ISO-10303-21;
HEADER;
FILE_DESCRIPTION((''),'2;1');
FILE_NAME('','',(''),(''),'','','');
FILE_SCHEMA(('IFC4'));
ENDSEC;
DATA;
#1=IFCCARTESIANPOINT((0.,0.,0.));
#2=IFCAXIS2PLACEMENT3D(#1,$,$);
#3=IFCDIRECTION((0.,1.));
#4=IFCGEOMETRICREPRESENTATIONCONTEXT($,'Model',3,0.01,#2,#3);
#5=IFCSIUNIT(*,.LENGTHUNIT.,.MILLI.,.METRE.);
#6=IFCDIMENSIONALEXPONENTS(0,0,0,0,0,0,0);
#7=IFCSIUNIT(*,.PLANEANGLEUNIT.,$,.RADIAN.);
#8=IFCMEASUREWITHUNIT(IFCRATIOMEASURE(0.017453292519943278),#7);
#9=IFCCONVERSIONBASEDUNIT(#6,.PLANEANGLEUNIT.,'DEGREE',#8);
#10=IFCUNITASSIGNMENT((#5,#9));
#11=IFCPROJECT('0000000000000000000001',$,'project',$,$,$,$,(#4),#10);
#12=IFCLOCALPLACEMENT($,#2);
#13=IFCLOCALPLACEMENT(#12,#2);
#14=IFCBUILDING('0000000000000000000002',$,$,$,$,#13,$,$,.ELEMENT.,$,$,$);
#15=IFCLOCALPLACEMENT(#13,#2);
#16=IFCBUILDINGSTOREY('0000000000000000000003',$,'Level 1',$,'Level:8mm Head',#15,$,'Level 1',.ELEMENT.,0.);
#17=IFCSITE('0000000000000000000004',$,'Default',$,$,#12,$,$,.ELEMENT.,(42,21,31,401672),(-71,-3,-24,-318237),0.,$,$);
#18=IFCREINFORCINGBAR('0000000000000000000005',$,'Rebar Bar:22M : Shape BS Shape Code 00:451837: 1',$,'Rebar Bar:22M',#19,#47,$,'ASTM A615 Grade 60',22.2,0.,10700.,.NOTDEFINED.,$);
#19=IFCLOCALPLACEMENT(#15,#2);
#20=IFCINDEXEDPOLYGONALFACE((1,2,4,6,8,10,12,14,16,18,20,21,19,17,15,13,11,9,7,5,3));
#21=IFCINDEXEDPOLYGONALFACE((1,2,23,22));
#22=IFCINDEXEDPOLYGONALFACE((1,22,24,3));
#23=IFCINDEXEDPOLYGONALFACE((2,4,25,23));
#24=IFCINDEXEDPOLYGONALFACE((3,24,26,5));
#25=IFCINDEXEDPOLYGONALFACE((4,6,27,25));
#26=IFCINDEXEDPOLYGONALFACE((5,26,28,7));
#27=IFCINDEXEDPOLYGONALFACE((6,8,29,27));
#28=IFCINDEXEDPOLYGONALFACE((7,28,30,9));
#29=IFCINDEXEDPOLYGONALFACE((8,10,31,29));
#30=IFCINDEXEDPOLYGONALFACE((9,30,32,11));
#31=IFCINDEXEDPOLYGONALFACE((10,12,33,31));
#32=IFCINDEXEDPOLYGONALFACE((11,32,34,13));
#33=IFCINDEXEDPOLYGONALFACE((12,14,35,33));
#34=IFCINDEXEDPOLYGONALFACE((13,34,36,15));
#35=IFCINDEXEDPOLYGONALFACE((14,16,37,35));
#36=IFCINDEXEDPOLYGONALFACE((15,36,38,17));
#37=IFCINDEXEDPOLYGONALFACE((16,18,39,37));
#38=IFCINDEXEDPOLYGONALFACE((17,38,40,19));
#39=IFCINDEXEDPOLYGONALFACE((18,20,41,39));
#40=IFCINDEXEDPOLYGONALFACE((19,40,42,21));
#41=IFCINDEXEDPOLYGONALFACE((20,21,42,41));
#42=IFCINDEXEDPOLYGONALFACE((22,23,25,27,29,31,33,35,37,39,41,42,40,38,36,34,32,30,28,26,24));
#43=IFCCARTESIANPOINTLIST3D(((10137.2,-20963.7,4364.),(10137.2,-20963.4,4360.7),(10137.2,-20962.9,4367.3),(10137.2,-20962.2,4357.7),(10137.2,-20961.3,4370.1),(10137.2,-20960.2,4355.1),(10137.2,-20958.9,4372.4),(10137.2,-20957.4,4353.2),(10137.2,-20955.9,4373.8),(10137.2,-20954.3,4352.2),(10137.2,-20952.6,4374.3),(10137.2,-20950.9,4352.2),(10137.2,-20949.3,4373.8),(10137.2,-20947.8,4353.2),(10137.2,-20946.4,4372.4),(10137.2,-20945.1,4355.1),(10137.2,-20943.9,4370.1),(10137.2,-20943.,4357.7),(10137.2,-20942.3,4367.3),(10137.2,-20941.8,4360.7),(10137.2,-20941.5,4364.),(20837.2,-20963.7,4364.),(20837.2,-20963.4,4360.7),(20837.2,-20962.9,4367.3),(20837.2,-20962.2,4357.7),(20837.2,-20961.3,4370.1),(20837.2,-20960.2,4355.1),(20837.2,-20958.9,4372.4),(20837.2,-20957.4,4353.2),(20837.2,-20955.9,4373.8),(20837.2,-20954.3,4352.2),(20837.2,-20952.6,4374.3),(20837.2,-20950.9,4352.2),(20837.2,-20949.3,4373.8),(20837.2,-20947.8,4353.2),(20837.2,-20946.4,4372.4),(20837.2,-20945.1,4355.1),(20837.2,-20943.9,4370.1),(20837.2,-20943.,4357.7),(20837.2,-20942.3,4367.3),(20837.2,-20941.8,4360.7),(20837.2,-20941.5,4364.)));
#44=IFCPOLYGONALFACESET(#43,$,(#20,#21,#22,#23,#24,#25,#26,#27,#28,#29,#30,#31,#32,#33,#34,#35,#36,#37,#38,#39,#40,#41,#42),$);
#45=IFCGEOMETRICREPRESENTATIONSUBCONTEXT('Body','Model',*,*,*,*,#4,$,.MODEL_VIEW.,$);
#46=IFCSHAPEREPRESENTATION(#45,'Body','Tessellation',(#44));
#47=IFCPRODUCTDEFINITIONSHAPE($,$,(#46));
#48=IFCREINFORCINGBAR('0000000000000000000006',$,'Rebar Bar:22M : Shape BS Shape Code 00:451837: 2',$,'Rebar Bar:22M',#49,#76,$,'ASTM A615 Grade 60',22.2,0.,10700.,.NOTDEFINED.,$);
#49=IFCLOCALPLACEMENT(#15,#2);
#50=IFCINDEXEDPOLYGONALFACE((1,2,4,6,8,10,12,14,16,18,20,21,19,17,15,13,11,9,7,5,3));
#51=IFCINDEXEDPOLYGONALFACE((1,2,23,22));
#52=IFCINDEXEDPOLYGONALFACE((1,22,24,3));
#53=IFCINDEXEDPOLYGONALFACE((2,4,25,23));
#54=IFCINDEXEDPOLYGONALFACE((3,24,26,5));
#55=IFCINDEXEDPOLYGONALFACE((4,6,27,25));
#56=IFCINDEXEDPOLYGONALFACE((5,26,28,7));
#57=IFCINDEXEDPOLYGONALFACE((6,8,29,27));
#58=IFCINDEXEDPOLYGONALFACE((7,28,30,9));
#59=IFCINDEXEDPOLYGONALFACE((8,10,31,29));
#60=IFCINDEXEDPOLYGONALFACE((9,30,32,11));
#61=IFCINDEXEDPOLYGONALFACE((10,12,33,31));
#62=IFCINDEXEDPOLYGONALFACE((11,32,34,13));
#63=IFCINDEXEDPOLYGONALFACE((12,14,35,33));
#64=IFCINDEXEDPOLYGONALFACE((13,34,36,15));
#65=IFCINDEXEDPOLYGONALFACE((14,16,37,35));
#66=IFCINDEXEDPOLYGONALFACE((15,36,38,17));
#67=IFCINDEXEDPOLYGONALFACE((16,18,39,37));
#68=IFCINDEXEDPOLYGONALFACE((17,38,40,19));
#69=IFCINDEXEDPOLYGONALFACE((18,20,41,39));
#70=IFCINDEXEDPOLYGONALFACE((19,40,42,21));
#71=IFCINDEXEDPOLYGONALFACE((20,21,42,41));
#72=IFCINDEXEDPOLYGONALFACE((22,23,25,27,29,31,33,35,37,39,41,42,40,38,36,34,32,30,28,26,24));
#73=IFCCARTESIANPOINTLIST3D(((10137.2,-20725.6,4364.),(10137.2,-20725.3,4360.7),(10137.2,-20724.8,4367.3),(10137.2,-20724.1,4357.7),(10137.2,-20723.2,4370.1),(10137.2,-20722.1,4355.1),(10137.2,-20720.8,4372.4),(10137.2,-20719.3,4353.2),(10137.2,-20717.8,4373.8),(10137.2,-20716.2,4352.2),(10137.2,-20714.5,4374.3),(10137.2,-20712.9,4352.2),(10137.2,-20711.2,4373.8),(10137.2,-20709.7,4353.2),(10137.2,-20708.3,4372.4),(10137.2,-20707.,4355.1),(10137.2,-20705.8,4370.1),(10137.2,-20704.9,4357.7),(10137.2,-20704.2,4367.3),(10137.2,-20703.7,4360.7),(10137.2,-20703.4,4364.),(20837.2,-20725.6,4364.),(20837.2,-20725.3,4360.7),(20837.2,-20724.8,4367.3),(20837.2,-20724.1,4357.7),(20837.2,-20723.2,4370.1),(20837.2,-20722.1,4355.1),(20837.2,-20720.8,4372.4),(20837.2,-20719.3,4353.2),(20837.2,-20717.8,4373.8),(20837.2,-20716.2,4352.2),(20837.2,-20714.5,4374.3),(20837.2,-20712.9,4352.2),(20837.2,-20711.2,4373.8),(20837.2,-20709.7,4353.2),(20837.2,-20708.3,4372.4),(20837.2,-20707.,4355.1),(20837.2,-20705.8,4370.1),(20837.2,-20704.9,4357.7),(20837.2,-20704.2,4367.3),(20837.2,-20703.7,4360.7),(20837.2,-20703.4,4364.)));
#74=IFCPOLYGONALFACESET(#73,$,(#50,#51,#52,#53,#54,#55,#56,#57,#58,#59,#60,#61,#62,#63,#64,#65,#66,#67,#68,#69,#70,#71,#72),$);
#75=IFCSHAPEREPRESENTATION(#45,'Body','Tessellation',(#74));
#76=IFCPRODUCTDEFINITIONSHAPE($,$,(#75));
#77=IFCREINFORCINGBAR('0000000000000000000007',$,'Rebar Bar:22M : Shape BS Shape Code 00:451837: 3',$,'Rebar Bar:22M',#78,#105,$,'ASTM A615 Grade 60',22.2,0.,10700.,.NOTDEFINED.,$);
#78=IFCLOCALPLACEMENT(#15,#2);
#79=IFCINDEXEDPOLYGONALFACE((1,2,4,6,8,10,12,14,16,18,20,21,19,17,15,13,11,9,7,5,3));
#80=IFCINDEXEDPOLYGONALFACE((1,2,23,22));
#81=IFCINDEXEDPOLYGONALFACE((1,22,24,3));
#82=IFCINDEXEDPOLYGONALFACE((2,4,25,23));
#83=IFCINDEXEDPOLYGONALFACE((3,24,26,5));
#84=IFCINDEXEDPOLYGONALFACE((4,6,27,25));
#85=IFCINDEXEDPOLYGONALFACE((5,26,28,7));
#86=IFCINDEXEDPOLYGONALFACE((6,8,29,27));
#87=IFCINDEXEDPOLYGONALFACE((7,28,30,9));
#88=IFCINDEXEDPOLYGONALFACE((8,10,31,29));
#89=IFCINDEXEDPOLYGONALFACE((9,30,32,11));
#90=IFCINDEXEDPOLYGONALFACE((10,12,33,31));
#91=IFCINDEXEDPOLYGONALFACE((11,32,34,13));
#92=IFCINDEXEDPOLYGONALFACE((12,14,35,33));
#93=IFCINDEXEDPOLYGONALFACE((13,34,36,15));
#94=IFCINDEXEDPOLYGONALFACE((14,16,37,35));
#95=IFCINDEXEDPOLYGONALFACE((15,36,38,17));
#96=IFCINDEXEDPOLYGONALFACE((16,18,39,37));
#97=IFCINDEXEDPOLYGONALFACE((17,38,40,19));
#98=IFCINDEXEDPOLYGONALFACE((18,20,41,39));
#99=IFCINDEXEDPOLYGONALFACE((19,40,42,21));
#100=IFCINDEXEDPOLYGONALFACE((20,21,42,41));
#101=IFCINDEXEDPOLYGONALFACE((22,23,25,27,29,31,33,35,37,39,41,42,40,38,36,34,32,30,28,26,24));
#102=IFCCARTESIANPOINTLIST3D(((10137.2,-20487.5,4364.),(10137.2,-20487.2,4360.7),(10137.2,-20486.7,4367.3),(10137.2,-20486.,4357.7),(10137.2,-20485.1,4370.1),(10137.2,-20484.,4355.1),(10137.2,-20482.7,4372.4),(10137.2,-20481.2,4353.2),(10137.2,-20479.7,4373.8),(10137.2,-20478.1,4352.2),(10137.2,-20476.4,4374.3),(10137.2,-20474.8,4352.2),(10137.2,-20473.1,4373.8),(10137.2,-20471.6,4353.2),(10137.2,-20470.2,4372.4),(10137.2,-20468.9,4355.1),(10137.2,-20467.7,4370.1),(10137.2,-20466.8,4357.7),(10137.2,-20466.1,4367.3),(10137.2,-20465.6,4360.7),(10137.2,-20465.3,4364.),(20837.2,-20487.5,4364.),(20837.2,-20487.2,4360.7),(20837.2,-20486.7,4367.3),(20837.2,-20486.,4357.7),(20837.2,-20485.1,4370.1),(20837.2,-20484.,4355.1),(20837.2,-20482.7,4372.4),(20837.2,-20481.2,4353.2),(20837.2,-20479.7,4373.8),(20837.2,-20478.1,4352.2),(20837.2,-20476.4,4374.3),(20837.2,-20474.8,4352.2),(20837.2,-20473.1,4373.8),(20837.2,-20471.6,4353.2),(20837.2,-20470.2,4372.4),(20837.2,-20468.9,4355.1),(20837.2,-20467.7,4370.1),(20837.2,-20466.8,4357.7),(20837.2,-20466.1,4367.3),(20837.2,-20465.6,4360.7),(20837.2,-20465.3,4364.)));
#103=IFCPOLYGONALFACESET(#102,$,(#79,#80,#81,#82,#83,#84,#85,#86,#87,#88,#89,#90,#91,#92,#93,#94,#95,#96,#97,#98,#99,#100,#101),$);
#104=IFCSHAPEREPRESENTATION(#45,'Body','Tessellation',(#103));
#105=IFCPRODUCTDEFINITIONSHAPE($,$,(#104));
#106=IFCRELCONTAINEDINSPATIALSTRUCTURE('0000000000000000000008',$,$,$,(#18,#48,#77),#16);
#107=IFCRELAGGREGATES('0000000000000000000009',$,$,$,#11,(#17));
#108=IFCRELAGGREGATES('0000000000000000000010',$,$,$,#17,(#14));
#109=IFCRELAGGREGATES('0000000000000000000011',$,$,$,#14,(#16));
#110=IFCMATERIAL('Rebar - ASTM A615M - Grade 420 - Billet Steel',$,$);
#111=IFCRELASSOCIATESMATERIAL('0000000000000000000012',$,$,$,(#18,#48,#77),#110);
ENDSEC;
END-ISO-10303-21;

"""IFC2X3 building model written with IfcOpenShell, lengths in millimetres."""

from ifc_helpers import new_model, entity, si_unit, converted_unit, direction, origin, place, context, subcontext, project, spatial, material, element, save


model = new_model("IFC2X3")

# Units and contexts
model_context = context("Model", 3, precision=0.01, world=origin(), true_north=direction((0.0, 1.0)))
body_context = subcontext(model_context, "Body", "Model", "MODEL_VIEW")
ifc_project = project(units=[si_unit("LENGTHUNIT", "METRE", prefix="MILLI"), converted_unit("PLANEANGLEUNIT", "DEGREE", entity("IfcRatioMeasure", 0.017453292519943278), si_unit("PLANEANGLEUNIT", "RADIAN"), dimensions=[0, 0, 0, 0, 0, 0, 0])], contexts=[model_context])

# Site, building, storey
site_placement = place(None, origin())
site = spatial("IfcSite", under=ifc_project, at=site_placement, Name="Default", CompositionType="ELEMENT", RefLatitude=(42, 21, 31, 401672), RefLongitude=(-71, -3, -24, -318237), RefElevation=0.0)
building_placement = place(site_placement, origin())
building = spatial("IfcBuilding", under=site, at=building_placement, CompositionType="ELEMENT")
storey_placement = place(building_placement, origin())
storey = spatial("IfcBuildingStorey", under=building, at=storey_placement, Name="Level 1", ObjectType="Level:8mm Head", LongName="Level 1", CompositionType="ELEMENT", Elevation=0.0)

# Reinforcing bars
ifc_material = material(Name="Rebar - ASTM A615M - Grade 420 - Billet Steel")
reinforcing_bar_1_placement = place(storey_placement, origin())
element("IfcReinforcingBar", 1, at=reinforcing_bar_1_placement, inside=storey, material=ifc_material, Name="Rebar Bar:22M : Shape BS Shape Code 00:451837: 1", SteelGrade="ASTM A615 Grade 60", ObjectType="Rebar Bar:22M", BarLength=10700.0, BarRole="NOTDEFINED", CrossSectionArea=0.0, NominalDiameter=22.2, context=body_context, shape_type="AdvancedSweptSolid", body=[
    entity("IfcSweptDiskSolid", entity("IfcCompositeCurve", [entity("IfcCompositeCurveSegment", "CONTINUOUS", True, entity("IfcPolyline", [entity("IfcCartesianPoint", [10137.2, -20952.6, 4363.2]), entity("IfcCartesianPoint", [20837.2, -20952.6, 4363.2])]))], False), 11.1, None, 0.0, 1.0),
])
reinforcing_bar_2_placement = place(storey_placement, origin())
element("IfcReinforcingBar", 2, at=reinforcing_bar_2_placement, inside=storey, material=ifc_material, Name="Rebar Bar:22M : Shape BS Shape Code 00:451837: 2", SteelGrade="ASTM A615 Grade 60", ObjectType="Rebar Bar:22M", BarLength=10700.0, BarRole="NOTDEFINED", CrossSectionArea=0.0, NominalDiameter=22.2, context=body_context, shape_type="AdvancedSweptSolid", body=[
    entity("IfcSweptDiskSolid", entity("IfcCompositeCurve", [entity("IfcCompositeCurveSegment", "CONTINUOUS", True, entity("IfcPolyline", [entity("IfcCartesianPoint", [10137.2, -20714.5, 4363.2]), entity("IfcCartesianPoint", [20837.2, -20714.5, 4363.2])]))], False), 11.1, None, 0.0, 1.0),
])
reinforcing_bar_3_placement = place(storey_placement, origin())
element("IfcReinforcingBar", 3, at=reinforcing_bar_3_placement, inside=storey, material=ifc_material, Name="Rebar Bar:22M : Shape BS Shape Code 00:451837: 3", SteelGrade="ASTM A615 Grade 60", ObjectType="Rebar Bar:22M", BarLength=10700.0, BarRole="NOTDEFINED", CrossSectionArea=0.0, NominalDiameter=22.2, context=body_context, shape_type="AdvancedSweptSolid", body=[
    entity("IfcSweptDiskSolid", entity("IfcCompositeCurve", [entity("IfcCompositeCurveSegment", "CONTINUOUS", True, entity("IfcPolyline", [entity("IfcCartesianPoint", [10137.2, -20476.4, 4363.2]), entity("IfcCartesianPoint", [20837.2, -20476.4, 4363.2])]))], False), 11.1, None, 0.0, 1.0),
])

save(model, "model.ifc")
